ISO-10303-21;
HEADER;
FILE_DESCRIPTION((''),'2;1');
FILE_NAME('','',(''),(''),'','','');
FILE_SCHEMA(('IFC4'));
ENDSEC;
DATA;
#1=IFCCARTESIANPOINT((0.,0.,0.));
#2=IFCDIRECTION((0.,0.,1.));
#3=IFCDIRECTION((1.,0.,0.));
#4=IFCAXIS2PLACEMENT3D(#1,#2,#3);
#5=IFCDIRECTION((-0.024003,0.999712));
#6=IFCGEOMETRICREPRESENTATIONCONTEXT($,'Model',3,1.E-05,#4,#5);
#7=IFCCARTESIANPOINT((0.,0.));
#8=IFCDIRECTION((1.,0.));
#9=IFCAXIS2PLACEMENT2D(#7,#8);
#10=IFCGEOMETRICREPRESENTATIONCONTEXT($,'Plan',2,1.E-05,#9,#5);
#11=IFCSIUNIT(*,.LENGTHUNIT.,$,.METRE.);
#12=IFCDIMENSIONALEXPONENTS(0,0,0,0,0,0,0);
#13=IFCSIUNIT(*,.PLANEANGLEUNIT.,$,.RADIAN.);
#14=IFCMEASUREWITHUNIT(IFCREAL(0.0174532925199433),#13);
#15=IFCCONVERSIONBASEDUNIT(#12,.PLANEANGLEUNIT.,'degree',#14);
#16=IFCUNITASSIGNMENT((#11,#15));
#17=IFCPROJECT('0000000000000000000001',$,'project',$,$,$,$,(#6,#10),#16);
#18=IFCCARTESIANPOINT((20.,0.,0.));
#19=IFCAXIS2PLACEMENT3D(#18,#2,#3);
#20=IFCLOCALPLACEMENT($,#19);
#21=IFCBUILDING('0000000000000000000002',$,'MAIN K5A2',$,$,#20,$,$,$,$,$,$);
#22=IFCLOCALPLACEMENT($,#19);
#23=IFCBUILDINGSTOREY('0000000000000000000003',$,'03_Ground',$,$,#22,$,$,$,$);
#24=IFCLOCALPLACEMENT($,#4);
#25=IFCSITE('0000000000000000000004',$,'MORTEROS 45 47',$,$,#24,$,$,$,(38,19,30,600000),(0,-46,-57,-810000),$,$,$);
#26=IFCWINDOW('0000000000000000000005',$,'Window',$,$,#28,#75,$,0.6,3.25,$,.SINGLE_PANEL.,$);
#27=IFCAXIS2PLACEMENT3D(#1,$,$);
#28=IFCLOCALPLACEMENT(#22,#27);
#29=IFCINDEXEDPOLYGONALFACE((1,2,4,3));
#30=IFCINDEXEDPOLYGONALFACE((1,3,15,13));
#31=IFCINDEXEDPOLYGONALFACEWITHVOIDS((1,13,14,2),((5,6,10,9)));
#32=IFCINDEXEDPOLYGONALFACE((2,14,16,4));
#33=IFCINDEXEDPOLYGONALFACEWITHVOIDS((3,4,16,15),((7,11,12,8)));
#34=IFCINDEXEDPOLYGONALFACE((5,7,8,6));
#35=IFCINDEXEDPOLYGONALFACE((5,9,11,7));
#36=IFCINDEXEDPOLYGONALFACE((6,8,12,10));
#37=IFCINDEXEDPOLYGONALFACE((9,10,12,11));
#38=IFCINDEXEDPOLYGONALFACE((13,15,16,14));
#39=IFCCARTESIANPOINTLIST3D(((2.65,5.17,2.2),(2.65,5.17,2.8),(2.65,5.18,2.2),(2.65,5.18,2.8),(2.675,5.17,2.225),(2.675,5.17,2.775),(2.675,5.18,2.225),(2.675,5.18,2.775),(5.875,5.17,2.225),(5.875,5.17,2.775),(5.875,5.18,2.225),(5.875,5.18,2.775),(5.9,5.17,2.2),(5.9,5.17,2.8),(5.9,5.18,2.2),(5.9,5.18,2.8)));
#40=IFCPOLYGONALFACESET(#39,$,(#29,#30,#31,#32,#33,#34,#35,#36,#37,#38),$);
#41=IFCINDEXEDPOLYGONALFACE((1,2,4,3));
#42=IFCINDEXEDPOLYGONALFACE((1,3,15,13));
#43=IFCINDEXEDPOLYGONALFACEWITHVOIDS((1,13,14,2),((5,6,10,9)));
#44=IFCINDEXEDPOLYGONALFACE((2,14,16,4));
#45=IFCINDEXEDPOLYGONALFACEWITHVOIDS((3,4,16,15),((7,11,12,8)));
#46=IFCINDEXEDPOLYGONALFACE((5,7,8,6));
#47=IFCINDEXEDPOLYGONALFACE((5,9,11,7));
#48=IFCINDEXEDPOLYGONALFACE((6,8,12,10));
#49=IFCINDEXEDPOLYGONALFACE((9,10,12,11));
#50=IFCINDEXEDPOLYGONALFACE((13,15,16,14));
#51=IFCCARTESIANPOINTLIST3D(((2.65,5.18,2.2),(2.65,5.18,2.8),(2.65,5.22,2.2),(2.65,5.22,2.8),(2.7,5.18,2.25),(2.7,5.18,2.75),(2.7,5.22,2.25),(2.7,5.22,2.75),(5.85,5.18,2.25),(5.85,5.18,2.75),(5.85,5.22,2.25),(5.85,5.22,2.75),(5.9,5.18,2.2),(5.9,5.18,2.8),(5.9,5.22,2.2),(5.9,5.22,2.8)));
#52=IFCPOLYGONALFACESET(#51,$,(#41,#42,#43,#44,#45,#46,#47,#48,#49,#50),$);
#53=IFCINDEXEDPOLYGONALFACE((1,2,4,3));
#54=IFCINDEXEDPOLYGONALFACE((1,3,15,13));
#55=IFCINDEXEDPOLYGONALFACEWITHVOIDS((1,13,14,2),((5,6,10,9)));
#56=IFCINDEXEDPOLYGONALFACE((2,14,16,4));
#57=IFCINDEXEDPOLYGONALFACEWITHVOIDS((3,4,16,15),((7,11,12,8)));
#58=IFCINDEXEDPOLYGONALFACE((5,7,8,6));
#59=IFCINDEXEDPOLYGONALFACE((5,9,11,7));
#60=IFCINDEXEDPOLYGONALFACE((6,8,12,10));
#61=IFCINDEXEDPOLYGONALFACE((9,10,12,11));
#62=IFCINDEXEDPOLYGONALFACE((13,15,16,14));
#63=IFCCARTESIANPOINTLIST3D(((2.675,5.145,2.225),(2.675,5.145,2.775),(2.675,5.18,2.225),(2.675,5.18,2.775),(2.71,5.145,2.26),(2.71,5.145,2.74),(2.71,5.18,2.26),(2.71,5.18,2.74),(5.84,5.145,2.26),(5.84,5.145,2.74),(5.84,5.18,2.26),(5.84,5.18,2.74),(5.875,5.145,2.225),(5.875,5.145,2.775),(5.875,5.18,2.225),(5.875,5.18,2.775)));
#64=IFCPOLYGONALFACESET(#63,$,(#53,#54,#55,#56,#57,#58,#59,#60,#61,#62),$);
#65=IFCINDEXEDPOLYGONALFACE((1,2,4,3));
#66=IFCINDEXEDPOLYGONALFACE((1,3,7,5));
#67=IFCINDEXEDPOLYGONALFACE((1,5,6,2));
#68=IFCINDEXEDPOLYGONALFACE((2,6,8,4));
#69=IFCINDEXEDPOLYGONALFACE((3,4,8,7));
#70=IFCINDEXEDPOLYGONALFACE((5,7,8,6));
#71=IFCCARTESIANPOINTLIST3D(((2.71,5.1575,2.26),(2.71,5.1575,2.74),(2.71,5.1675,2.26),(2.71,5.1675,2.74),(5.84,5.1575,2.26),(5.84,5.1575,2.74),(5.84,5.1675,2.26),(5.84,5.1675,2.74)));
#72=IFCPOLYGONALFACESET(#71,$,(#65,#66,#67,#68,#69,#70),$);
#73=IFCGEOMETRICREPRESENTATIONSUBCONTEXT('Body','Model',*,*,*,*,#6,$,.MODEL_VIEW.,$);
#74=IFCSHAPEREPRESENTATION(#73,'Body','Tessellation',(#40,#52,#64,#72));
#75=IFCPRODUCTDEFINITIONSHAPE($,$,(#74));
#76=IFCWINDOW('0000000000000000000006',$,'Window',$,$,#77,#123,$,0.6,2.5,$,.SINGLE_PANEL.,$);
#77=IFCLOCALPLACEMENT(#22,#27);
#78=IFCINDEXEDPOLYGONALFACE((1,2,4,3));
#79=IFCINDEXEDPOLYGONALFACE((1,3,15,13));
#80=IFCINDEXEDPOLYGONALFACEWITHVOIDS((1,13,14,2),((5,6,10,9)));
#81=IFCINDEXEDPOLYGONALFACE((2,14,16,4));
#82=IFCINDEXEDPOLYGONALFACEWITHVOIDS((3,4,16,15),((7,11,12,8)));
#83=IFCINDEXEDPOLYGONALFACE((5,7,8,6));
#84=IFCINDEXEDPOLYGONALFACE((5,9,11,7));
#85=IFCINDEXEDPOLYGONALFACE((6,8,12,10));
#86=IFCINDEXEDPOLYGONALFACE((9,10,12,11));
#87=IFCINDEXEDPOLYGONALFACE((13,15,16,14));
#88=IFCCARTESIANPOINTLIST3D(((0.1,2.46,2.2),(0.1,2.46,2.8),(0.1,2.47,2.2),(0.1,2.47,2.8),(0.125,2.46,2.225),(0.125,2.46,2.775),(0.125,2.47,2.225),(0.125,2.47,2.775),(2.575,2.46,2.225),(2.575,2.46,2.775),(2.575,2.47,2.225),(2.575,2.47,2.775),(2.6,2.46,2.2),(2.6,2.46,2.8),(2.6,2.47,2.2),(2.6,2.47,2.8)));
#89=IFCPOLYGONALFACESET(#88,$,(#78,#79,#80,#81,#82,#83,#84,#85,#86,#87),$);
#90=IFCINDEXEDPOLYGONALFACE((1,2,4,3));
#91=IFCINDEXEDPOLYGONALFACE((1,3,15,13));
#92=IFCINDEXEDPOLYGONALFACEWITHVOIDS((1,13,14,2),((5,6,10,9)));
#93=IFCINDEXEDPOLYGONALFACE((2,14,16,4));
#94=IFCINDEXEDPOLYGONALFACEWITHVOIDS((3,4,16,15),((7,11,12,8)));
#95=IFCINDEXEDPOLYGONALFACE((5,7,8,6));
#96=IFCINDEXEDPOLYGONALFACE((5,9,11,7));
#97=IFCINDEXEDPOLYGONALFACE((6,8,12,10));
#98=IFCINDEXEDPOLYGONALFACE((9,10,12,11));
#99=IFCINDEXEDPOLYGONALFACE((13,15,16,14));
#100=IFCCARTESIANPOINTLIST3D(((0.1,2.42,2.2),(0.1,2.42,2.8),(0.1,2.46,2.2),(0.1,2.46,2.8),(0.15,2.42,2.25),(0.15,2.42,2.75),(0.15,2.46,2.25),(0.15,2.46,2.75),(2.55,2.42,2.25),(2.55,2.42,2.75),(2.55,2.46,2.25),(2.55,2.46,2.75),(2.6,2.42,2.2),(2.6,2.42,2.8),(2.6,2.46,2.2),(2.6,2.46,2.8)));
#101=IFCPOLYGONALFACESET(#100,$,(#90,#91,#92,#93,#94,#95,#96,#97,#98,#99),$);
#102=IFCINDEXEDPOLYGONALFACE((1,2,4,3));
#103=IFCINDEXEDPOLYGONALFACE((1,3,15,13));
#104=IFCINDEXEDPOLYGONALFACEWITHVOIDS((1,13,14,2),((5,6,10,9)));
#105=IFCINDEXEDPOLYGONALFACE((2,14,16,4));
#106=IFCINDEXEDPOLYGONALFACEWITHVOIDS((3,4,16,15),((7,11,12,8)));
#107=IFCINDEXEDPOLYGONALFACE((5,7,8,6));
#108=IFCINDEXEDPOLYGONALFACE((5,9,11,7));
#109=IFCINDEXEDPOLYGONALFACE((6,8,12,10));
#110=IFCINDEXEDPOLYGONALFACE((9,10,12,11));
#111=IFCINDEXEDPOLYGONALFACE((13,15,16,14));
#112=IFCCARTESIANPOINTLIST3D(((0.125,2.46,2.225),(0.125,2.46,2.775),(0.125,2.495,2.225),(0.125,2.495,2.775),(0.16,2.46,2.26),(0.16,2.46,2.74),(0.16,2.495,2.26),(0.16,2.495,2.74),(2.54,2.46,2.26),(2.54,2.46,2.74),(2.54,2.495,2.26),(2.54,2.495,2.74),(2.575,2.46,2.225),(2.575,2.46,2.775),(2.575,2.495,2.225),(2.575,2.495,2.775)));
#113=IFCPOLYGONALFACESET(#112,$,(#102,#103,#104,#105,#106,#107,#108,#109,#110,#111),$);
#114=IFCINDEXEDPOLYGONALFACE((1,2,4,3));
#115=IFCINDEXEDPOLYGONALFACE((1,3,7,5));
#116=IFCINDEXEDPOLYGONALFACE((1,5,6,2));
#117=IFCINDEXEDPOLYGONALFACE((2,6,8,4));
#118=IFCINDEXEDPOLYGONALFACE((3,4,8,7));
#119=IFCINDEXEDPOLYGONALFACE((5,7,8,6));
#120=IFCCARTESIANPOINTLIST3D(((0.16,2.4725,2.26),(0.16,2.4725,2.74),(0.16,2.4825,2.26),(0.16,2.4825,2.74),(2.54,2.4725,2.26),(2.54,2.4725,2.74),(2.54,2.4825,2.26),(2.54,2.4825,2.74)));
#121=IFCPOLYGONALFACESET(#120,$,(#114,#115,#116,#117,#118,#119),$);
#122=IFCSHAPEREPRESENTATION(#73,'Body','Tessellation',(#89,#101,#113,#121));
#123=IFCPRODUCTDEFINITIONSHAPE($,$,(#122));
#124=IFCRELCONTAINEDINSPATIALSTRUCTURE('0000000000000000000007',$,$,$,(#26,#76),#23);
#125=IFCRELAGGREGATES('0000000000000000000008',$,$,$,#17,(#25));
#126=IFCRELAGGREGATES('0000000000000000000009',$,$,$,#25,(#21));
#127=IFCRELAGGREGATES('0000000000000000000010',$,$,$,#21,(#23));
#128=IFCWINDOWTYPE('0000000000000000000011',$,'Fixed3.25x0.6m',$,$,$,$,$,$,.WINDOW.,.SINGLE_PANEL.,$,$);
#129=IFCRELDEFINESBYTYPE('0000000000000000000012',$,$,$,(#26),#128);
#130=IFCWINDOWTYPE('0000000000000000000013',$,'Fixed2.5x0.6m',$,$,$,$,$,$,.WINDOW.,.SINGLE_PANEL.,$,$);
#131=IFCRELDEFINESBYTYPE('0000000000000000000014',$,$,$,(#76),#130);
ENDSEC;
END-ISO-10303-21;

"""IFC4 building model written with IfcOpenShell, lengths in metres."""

from ifc_helpers import new_model, entity, si_unit, converted_unit, direction, frame, origin_with_axes, origin_2d_with_axis, place, context, subcontext, project, spatial, line, indexed_curve, outline, extrude, shape, source, transform, mapped, type_object, element, save


model = new_model("IFC4")

# Units and contexts
model_context = context("Model", 3, precision=1e-05, world=origin_with_axes(), true_north=direction((-0.024003, 0.999712)))
plan_context = context("Plan", 2, precision=1e-05, world=origin_2d_with_axis(), true_north=direction((-0.024003, 0.999712)))
body_context_1 = subcontext(model_context, "Body", "Model", "MODEL_VIEW")
body_context_2 = subcontext(plan_context, "Body", "Plan", "PLAN_VIEW")
ifc_project = project(units=[si_unit("LENGTHUNIT", "METRE"), converted_unit("PLANEANGLEUNIT", "degree", entity("IfcReal", 0.0174532925199433), si_unit("PLANEANGLEUNIT", "RADIAN"), dimensions=[0, 0, 0, 0, 0, 0, 0])], contexts=[model_context, plan_context])

# Site, building, storey
site_placement = place(None, origin_with_axes())
site = spatial("IfcSite", under=ifc_project, at=site_placement, Name="MORTEROS 45 47", RefLatitude=(38, 19, 30, 600000), RefLongitude=(0, -46, -57, -810000))
building_placement = place(None, frame((20.0, 0.0, 0.0), z_axis=(0.0, 0.0, 1.0), x_axis=(1.0, 0.0, 0.0)))
building = spatial("IfcBuilding", under=site, at=building_placement, Name="MAIN K5A2")
storey_placement = place(None, frame((20.0, 0.0, 0.0), z_axis=(0.0, 0.0, 1.0), x_axis=(1.0, 0.0, 0.0)))
storey = spatial("IfcBuildingStorey", under=building, at=storey_placement, Name="03_Ground")

# Windows
window_type_1 = type_object("IfcWindowType", Name="Fixed3.25x0.6m", PartitioningType="SINGLE_PANEL", PredefinedType="WINDOW")
shared_shape_1 = source(origin_with_axes(), body_context_1, "Body", "SolidModel", [
    extrude(outline(indexed_curve([(0.0, 0.0), (3.25, 0.0), (3.25, 0.6), (0.0, 0.6)], segments=[line(1, 2, 3, 4, 1)]), holes=[indexed_curve([(0.025, 0.025), (3.225, 0.025), (3.225, 0.575), (0.025, 0.575)], segments=[line(1, 2, 3, 4, 1)])]), frame((0.0, 0.09, 0.0), z_axis=(0.0, -1.0, 0.0), x_axis=(1.0, 0.0, 0.0)), (0.0, 0.0, -1.0), 0.01),
    extrude(outline(indexed_curve([(0.0, 0.0), (3.25, 0.0), (3.25, 0.6), (0.0, 0.6)], segments=[line(1, 2, 3, 4, 1)]), holes=[indexed_curve([(0.05, 0.05), (3.2, 0.05), (3.2, 0.55), (0.05, 0.55)], segments=[line(1, 2, 3, 4, 1)])]), frame((0.0, 0.05, 0.0), z_axis=(0.0, -1.0, 0.0), x_axis=(1.0, 0.0, 0.0)), (0.0, 0.0, -1.0), 0.04),
    extrude(outline(indexed_curve([(0.0, 0.0), (3.2, 0.0), (3.2, 0.55), (0.0, 0.55)], segments=[line(1, 2, 3, 4, 1)]), holes=[indexed_curve([(0.035, 0.035), (3.165, 0.035), (3.165, 0.515), (0.035, 0.515)], segments=[line(1, 2, 3, 4, 1)])]), frame((0.025, 0.09, 0.025), z_axis=(0.0, -1.0, 0.0), x_axis=(1.0, 0.0, 0.0)), (0.0, 0.0, -1.0), 0.035),
    extrude(outline(indexed_curve([(0.035, 0.035), (3.165, 0.035), (3.165, 0.515), (0.035, 0.515)], segments=[line(1, 2, 3, 4, 1)])), frame((0.025, 0.1025, 0.025), z_axis=(0.0, -1.0, 0.0), x_axis=(1.0, 0.0, 0.0)), (0.0, 0.0, -1.0), 0.01),
])
shared_shape_2 = source(origin_with_axes(), body_context_2, "Body", "Curve2D", [
    entity("IfcIndexedPolyCurve", entity("IfcCartesianPointList2D", [[0.05, 0.05], [3.2, 0.05]])),
    entity("IfcIndexedPolyCurve", entity("IfcCartesianPointList2D", [[0.0, 0.1], [0.025, 0.1], [0.025, 0.09], [0.05, 0.09], [0.05, 0.05], [0.0, 0.05]]), [entity("IfcLineIndex", [1, 2, 3, 4, 5, 6, 1])]),
    entity("IfcIndexedPolyCurve", entity("IfcCartesianPointList2D", [[3.25, 0.1], [3.225, 0.1], [3.225, 0.09], [3.2, 0.09], [3.2, 0.05], [3.25, 0.05]]), [entity("IfcLineIndex", [1, 2, 3, 4, 5, 6, 1])]),
    entity("IfcIndexedPolyCurve", entity("IfcCartesianPointList2D", [[0.025, 0.09], [0.06, 0.09], [0.06, 0.125], [0.025, 0.125]]), [entity("IfcLineIndex", [1, 2, 3, 4, 1])]),
    entity("IfcIndexedPolyCurve", entity("IfcCartesianPointList2D", [[3.225, 0.09], [3.19, 0.09], [3.19, 0.125], [3.225, 0.125]]), [entity("IfcLineIndex", [1, 2, 3, 4, 1])]),
    entity("IfcIndexedPolyCurve", entity("IfcCartesianPointList2D", [[0.06, 0.09], [3.19, 0.09]])),
    entity("IfcIndexedPolyCurve", entity("IfcCartesianPointList2D", [[0.06, 0.125], [3.19, 0.125]])),
    entity("IfcIndexedPolyCurve", entity("IfcCartesianPointList2D", [[0.06, 0.1075], [3.19, 0.1075]])),
])
window_1_placement = place(None, frame((25.9, 5.27, 2.2), z_axis=(0.0, 0.0, 1.0), x_axis=(-1.0, 0.0, 0.0)))
element("IfcWindow", 1, at=window_1_placement, inside=storey, type_object=window_type_1, Name="Window", OverallHeight=0.6, OverallWidth=3.25, PartitioningType="SINGLE_PANEL", shapes=[
    shape(body_context_1, "Body", "MappedRepresentation", [mapped(shared_shape_1, transform((0.0, 0.0, 0.0), x_axis=(1.0, 0.0, 0.0), y_axis=(0.0, 1.0, 0.0), z_axis=(0.0, 0.0, 1.0), scale=1.0))]),
    shape(body_context_2, "Body", "MappedRepresentation", [mapped(shared_shape_2, transform((0.0, 0.0, 0.0), x_axis=(1.0, 0.0, 0.0), y_axis=(0.0, 1.0, 0.0), z_axis=(0.0, 0.0, 1.0), scale=1.0))]),
])
window_type_2 = type_object("IfcWindowType", Name="Fixed2.5x0.6m", PartitioningType="SINGLE_PANEL", PredefinedType="WINDOW")
shared_shape_3 = source(origin_with_axes(), body_context_1, "Body", "SolidModel", [
    extrude(outline(indexed_curve([(0.0, 0.0), (2.5, 0.0), (2.5, 0.6), (0.0, 0.6)], segments=[line(1, 2, 3, 4, 1)]), holes=[indexed_curve([(0.025, 0.025), (2.475, 0.025), (2.475, 0.575), (0.025, 0.575)], segments=[line(1, 2, 3, 4, 1)])]), frame((0.0, 0.09, 0.0), z_axis=(0.0, -1.0, 0.0), x_axis=(1.0, 0.0, 0.0)), (0.0, 0.0, -1.0), 0.01),
    extrude(outline(indexed_curve([(0.0, 0.0), (2.5, 0.0), (2.5, 0.6), (0.0, 0.6)], segments=[line(1, 2, 3, 4, 1)]), holes=[indexed_curve([(0.05, 0.05), (2.45, 0.05), (2.45, 0.55), (0.05, 0.55)], segments=[line(1, 2, 3, 4, 1)])]), frame((0.0, 0.05, 0.0), z_axis=(0.0, -1.0, 0.0), x_axis=(1.0, 0.0, 0.0)), (0.0, 0.0, -1.0), 0.04),
    extrude(outline(indexed_curve([(0.0, 0.0), (2.45, 0.0), (2.45, 0.55), (0.0, 0.55)], segments=[line(1, 2, 3, 4, 1)]), holes=[indexed_curve([(0.035, 0.035), (2.415, 0.035), (2.415, 0.515), (0.035, 0.515)], segments=[line(1, 2, 3, 4, 1)])]), frame((0.025, 0.09, 0.025), z_axis=(0.0, -1.0, 0.0), x_axis=(1.0, 0.0, 0.0)), (0.0, 0.0, -1.0), 0.035),
    extrude(outline(indexed_curve([(0.035, 0.035), (2.415, 0.035), (2.415, 0.515), (0.035, 0.515)], segments=[line(1, 2, 3, 4, 1)])), frame((0.025, 0.1025, 0.025), z_axis=(0.0, -1.0, 0.0), x_axis=(1.0, 0.0, 0.0)), (0.0, 0.0, -1.0), 0.01),
])
shared_shape_4 = source(origin_with_axes(), body_context_2, "Body", "Curve2D", [
    entity("IfcIndexedPolyCurve", entity("IfcCartesianPointList2D", [[0.05, 0.05], [2.45, 0.05]])),
    entity("IfcIndexedPolyCurve", entity("IfcCartesianPointList2D", [[0.0, 0.1], [0.025, 0.1], [0.025, 0.09], [0.05, 0.09], [0.05, 0.05], [0.0, 0.05]]), [entity("IfcLineIndex", [1, 2, 3, 4, 5, 6, 1])]),
    entity("IfcIndexedPolyCurve", entity("IfcCartesianPointList2D", [[2.5, 0.1], [2.475, 0.1], [2.475, 0.09], [2.45, 0.09], [2.45, 0.05], [2.5, 0.05]]), [entity("IfcLineIndex", [1, 2, 3, 4, 5, 6, 1])]),
    entity("IfcIndexedPolyCurve", entity("IfcCartesianPointList2D", [[0.025, 0.09], [0.06, 0.09], [0.06, 0.125], [0.025, 0.125]]), [entity("IfcLineIndex", [1, 2, 3, 4, 1])]),
    entity("IfcIndexedPolyCurve", entity("IfcCartesianPointList2D", [[2.475, 0.09], [2.44, 0.09], [2.44, 0.125], [2.475, 0.125]]), [entity("IfcLineIndex", [1, 2, 3, 4, 1])]),
    entity("IfcIndexedPolyCurve", entity("IfcCartesianPointList2D", [[0.06, 0.09], [2.44, 0.09]])),
    entity("IfcIndexedPolyCurve", entity("IfcCartesianPointList2D", [[0.06, 0.125], [2.44, 0.125]])),
    entity("IfcIndexedPolyCurve", entity("IfcCartesianPointList2D", [[0.06, 0.1075], [2.44, 0.1075]])),
])
window_2_placement = place(None, frame((20.1, 2.37, 2.2), z_axis=(0.0, 0.0, 1.0), x_axis=(1.0, 0.000001, 0.0)))
element("IfcWindow", 2, at=window_2_placement, inside=storey, type_object=window_type_2, Name="Window", OverallHeight=0.6, OverallWidth=2.5, PartitioningType="SINGLE_PANEL", shapes=[
    shape(body_context_1, "Body", "MappedRepresentation", [mapped(shared_shape_3, transform((0.0, 0.0, 0.0), x_axis=(1.0, 0.0, 0.0), y_axis=(0.0, 1.0, 0.0), z_axis=(0.0, 0.0, 1.0), scale=1.0))]),
    shape(body_context_2, "Body", "MappedRepresentation", [mapped(shared_shape_4, transform((0.0, 0.0, 0.0), x_axis=(1.0, 0.0, 0.0), y_axis=(0.0, 1.0, 0.0), z_axis=(0.0, 0.0, 1.0), scale=1.0))]),
])

save(model, "model.ifc")
